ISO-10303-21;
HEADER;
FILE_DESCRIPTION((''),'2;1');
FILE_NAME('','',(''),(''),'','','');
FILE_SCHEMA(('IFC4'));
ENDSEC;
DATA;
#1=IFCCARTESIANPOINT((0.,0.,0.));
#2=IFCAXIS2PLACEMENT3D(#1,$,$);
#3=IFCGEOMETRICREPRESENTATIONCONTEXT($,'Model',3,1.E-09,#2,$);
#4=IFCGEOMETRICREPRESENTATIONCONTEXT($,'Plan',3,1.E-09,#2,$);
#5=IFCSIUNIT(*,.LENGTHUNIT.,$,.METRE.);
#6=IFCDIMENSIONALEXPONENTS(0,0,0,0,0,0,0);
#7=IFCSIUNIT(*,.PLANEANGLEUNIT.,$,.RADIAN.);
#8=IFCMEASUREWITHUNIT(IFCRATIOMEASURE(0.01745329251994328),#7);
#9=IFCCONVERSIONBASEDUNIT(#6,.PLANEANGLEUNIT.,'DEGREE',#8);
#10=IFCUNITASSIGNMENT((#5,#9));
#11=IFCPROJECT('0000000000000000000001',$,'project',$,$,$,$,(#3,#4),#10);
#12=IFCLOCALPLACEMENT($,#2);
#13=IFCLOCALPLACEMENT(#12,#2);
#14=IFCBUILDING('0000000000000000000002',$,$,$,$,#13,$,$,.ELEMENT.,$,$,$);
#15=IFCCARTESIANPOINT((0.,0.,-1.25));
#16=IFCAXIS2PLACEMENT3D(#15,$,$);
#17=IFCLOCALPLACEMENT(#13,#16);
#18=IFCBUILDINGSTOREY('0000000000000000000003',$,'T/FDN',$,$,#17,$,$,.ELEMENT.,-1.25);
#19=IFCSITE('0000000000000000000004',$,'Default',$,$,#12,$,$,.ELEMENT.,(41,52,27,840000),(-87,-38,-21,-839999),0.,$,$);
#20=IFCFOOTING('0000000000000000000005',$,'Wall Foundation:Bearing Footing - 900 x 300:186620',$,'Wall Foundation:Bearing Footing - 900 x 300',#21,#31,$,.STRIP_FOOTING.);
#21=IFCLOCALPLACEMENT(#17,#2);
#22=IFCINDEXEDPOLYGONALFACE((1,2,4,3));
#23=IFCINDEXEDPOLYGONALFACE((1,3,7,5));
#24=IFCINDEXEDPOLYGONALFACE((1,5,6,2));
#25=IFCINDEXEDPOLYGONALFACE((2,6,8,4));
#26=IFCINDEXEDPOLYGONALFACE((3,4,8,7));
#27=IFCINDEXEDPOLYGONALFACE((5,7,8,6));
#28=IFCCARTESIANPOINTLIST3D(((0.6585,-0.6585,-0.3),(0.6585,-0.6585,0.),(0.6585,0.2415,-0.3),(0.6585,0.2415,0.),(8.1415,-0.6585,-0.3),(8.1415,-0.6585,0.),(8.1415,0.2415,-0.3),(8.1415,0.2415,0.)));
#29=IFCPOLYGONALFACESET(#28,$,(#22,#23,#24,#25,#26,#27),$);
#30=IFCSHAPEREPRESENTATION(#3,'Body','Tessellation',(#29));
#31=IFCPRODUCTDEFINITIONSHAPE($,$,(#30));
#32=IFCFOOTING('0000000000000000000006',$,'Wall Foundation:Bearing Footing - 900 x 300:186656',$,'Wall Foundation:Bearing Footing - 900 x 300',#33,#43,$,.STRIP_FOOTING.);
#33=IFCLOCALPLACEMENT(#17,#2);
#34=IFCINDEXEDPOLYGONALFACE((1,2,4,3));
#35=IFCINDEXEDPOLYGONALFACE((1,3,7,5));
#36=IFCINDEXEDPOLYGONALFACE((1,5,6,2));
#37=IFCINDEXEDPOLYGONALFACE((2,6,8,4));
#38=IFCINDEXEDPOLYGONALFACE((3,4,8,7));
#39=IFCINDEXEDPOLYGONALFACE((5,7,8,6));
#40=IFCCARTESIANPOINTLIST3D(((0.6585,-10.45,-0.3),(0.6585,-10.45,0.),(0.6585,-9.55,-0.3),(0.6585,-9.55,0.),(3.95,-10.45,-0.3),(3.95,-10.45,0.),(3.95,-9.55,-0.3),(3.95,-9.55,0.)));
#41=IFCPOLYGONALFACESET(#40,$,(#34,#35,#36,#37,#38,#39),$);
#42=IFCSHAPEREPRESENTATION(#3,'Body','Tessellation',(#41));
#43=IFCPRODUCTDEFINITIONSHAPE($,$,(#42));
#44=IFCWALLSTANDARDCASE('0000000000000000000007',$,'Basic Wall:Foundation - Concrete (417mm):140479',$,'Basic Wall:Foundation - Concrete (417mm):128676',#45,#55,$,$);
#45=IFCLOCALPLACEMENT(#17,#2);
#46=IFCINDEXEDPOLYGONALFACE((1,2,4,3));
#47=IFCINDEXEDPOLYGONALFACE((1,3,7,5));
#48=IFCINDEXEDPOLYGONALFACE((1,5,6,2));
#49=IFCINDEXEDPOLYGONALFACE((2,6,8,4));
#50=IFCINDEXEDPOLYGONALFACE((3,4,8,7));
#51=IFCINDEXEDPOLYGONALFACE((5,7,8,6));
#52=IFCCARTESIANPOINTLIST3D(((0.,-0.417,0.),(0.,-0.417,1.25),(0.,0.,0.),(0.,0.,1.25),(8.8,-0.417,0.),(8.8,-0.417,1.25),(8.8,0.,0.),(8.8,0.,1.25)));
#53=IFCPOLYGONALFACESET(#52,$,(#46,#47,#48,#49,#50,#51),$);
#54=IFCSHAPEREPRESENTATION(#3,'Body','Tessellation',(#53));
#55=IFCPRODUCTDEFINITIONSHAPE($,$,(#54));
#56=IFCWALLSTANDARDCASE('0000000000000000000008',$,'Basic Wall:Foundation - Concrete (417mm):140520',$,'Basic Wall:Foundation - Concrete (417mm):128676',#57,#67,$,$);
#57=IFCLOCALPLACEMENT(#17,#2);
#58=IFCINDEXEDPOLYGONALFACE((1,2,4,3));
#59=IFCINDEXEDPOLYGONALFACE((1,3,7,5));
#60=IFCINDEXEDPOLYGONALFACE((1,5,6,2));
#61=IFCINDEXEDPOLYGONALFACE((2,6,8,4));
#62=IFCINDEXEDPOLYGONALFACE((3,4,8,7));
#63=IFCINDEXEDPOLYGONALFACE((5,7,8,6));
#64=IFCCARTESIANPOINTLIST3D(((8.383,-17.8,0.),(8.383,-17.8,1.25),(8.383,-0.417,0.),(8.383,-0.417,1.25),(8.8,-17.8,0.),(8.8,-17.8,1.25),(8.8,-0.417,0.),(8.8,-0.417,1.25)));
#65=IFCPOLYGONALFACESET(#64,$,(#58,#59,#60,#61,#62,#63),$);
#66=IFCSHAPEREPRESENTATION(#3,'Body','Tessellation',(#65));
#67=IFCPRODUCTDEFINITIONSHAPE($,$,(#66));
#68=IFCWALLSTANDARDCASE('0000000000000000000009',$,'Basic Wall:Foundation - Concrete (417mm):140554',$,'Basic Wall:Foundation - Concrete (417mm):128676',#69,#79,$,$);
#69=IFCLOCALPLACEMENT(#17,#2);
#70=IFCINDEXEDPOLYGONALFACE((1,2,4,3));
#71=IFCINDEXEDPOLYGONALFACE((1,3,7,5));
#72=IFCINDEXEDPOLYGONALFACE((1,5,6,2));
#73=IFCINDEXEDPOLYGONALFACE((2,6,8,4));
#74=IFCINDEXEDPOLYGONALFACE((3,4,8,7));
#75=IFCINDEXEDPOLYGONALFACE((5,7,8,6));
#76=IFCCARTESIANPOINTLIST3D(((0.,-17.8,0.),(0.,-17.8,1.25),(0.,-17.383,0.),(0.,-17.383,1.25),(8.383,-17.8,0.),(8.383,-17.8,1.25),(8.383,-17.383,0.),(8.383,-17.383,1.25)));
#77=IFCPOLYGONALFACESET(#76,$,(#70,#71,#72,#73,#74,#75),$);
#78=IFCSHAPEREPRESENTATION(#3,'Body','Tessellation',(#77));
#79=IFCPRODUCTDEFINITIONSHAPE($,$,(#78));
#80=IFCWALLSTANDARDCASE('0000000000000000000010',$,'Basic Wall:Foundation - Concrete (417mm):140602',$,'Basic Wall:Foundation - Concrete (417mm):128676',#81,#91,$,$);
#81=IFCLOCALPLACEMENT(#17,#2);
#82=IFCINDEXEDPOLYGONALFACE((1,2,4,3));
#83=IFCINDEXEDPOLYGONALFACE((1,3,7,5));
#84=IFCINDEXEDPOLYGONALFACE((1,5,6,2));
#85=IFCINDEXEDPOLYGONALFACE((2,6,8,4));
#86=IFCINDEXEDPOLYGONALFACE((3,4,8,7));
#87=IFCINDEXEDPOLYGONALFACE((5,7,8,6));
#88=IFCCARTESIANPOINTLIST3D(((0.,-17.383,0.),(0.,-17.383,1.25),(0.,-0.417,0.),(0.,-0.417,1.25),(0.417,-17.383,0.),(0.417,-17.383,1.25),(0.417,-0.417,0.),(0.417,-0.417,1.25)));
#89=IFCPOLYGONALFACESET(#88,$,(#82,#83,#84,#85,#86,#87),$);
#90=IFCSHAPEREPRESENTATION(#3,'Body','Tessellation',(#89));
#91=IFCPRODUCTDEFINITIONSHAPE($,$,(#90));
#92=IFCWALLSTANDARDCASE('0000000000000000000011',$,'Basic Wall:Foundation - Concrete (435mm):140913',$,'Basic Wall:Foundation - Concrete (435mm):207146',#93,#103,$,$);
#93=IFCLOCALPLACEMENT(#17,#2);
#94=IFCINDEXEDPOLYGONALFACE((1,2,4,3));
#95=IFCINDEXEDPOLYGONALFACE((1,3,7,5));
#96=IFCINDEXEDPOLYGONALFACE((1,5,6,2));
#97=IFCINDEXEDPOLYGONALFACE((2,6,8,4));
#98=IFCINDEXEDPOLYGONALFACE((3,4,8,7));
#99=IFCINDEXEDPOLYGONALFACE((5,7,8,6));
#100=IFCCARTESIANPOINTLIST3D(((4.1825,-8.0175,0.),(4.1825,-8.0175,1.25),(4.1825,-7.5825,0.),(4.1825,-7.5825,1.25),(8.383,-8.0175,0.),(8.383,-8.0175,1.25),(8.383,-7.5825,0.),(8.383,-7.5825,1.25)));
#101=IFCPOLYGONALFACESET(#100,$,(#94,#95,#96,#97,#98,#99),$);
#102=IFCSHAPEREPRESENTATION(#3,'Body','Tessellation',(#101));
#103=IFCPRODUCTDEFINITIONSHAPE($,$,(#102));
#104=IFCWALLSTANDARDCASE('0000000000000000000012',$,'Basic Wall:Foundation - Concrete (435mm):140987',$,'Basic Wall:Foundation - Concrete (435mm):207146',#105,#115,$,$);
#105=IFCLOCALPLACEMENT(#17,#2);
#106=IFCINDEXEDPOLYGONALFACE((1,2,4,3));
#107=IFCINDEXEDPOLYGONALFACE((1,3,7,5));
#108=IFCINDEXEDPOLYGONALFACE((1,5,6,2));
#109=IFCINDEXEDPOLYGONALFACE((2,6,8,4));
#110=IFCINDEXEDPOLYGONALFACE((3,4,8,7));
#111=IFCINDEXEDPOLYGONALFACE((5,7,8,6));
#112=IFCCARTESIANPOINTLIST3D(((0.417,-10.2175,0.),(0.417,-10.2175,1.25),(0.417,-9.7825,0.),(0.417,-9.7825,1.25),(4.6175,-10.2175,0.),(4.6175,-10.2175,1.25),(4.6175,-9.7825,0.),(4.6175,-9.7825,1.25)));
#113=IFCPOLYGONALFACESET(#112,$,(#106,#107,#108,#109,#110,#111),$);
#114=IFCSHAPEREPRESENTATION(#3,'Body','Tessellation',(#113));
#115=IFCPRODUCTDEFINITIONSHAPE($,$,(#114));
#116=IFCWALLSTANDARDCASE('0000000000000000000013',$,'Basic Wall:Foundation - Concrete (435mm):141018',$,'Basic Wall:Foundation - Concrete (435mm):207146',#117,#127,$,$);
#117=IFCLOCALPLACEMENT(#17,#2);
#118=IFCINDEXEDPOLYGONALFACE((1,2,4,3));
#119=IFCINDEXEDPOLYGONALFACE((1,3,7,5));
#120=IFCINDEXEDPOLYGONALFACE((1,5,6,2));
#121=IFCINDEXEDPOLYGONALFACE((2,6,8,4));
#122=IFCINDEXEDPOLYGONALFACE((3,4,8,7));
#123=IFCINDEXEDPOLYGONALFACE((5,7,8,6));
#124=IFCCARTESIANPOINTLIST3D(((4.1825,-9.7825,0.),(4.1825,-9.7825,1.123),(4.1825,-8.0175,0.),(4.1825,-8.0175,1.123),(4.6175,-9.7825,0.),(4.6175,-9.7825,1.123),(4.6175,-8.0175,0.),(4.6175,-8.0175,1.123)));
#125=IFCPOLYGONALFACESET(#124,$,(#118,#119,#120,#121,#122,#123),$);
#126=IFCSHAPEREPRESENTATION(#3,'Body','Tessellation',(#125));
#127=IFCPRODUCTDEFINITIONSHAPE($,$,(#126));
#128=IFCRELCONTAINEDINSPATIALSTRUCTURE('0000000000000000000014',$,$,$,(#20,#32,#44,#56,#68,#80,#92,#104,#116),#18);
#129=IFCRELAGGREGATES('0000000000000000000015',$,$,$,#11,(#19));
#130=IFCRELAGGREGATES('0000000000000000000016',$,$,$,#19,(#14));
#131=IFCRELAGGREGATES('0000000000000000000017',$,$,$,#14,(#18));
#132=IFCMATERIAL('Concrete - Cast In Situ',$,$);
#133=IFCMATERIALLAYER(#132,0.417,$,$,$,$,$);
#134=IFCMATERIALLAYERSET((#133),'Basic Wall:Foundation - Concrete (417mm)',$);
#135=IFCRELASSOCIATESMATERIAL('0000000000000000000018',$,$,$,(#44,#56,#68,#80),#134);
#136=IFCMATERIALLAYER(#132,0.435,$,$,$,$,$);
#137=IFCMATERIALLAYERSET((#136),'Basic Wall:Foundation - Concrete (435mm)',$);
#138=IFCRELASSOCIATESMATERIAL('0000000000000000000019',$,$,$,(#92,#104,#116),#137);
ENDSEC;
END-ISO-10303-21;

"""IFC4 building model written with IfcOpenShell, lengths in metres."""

from ifc_helpers import new_model, entity, si_unit, converted_unit, frame, frame_2d, origin, origin_2d_with_axis, place, context, project, spatial, rectangle, extrude, material, layer, layer_set, layer_usage, element, save


model = new_model("IFC4")

# Units and contexts
model_context = context("Model", 3, precision=1e-09, world=origin())
plan_context = context("Plan", 3, precision=1e-09, world=origin())
ifc_project = project(units=[si_unit("LENGTHUNIT", "METRE"), converted_unit("PLANEANGLEUNIT", "DEGREE", entity("IfcRatioMeasure", 0.01745329251994328), si_unit("PLANEANGLEUNIT", "RADIAN"), dimensions=[0, 0, 0, 0, 0, 0, 0])], contexts=[model_context, plan_context])

# Site, building, storey
site_placement = place(None, origin())
site = spatial("IfcSite", under=ifc_project, at=site_placement, Name="Default", CompositionType="ELEMENT", RefLatitude=(41, 52, 27, 840000), RefLongitude=(-87, -38, -21, -839999), RefElevation=0.0)
building_placement = place(site_placement, origin())
building = spatial("IfcBuilding", under=site, at=building_placement, CompositionType="ELEMENT")
storey_placement = place(building_placement, frame((0.0, 0.0, -1.25)))
storey = spatial("IfcBuildingStorey", under=building, at=storey_placement, Name="T/FDN", CompositionType="ELEMENT", Elevation=-1.25)

# Footings
footing_1_placement = place(storey_placement, origin())
element("IfcFooting", 1, at=footing_1_placement, inside=storey, Name="Wall Foundation:Bearing Footing - 900 x 300:186620", ObjectType="Wall Foundation:Bearing Footing - 900 x 300", PredefinedType="STRIP_FOOTING", context=model_context, shape_type="SweptSolid", body=[
    extrude(rectangle(XDim=7.483, YDim=0.9, at=origin_2d_with_axis()), frame((4.4, -0.2085, -0.3), z_axis=(0.0, 0.0, 1.0), x_axis=(-1.0, 0.0, 0.0)), (0.0, 0.0, 1.0), 0.3),
])
footing_2_placement = place(storey_placement, origin())
element("IfcFooting", 2, at=footing_2_placement, inside=storey, Name="Wall Foundation:Bearing Footing - 900 x 300:186656", ObjectType="Wall Foundation:Bearing Footing - 900 x 300", PredefinedType="STRIP_FOOTING", context=model_context, shape_type="SweptSolid", body=[
    extrude(rectangle(XDim=3.2915, YDim=0.9, at=origin_2d_with_axis()), frame((2.3042, -10.0, -0.3)), (0.0, 0.0, 1.0), 0.3),
])

# Walls
ifc_material = material(Name="Concrete - Cast In Situ")
ifc_layer_1 = layer(ifc_material, 0.417)
ifc_layer_set_1 = layer_set([ifc_layer_1], Name="Basic Wall:Foundation - Concrete (417mm)")
ifc_layer_usage_1 = layer_usage(ifc_layer_set_1, "AXIS2", "NEGATIVE", 0.2085)
wall_1_placement = place(storey_placement, frame((0.0, -0.2085, 0.0)))
element("IfcWallStandardCase", 3, at=wall_1_placement, inside=storey, material=ifc_layer_usage_1, Name="Basic Wall:Foundation - Concrete (417mm):140479", ObjectType="Basic Wall:Foundation - Concrete (417mm):128676", context=model_context, shape_type="SweptSolid", body=[
    extrude(rectangle(XDim=8.8, YDim=0.417, at=frame_2d((4.4, 0.0), x_axis=(-1.0, 0.0))), origin(), (0.0, 0.0, 1.0), 1.25),
])
ifc_layer_usage_2 = layer_usage(ifc_layer_set_1, "AXIS2", "NEGATIVE", 0.2085)
wall_2_placement = place(storey_placement, frame((8.5915, -0.417, 0.0), z_axis=(0.0, 0.0, 1.0), x_axis=(0.0, -1.0, 0.0)))
element("IfcWallStandardCase", 4, at=wall_2_placement, inside=storey, material=ifc_layer_usage_2, Name="Basic Wall:Foundation - Concrete (417mm):140520", ObjectType="Basic Wall:Foundation - Concrete (417mm):128676", context=model_context, shape_type="SweptSolid", body=[
    extrude(rectangle(XDim=17.383, YDim=0.417, at=frame_2d((8.6915, 0.0), x_axis=(-1.0, 0.0))), origin(), (0.0, 0.0, 1.0), 1.25),
])
ifc_layer_usage_3 = layer_usage(ifc_layer_set_1, "AXIS2", "NEGATIVE", 0.2085)
wall_3_placement = place(storey_placement, frame((8.383, -17.5915, 0.0), z_axis=(0.0, 0.0, 1.0), x_axis=(-1.0, 0.0, 0.0)))
element("IfcWallStandardCase", 5, at=wall_3_placement, inside=storey, material=ifc_layer_usage_3, Name="Basic Wall:Foundation - Concrete (417mm):140554", ObjectType="Basic Wall:Foundation - Concrete (417mm):128676", context=model_context, shape_type="SweptSolid", body=[
    extrude(rectangle(XDim=8.383, YDim=0.417, at=frame_2d((4.1915, 0.0), x_axis=(-1.0, 0.0))), origin(), (0.0, 0.0, 1.0), 1.25),
])
ifc_layer_usage_4 = layer_usage(ifc_layer_set_1, "AXIS2", "NEGATIVE", 0.2085)
wall_4_placement = place(storey_placement, frame((0.2085, -17.383, 0.0), z_axis=(0.0, 0.0, 1.0), x_axis=(0.0, 1.0, 0.0)))
element("IfcWallStandardCase", 6, at=wall_4_placement, inside=storey, material=ifc_layer_usage_4, Name="Basic Wall:Foundation - Concrete (417mm):140602", ObjectType="Basic Wall:Foundation - Concrete (417mm):128676", context=model_context, shape_type="SweptSolid", body=[
    extrude(rectangle(XDim=16.966, YDim=0.417, at=frame_2d((8.483, 0.0), x_axis=(-1.0, 0.0))), origin(), (0.0, 0.0, 1.0), 1.25),
])
ifc_layer_2 = layer(ifc_material, 0.435)
ifc_layer_set_2 = layer_set([ifc_layer_2], Name="Basic Wall:Foundation - Concrete (435mm)")
ifc_layer_usage_5 = layer_usage(ifc_layer_set_2, "AXIS2", "NEGATIVE", 0.2175)
wall_5_placement = place(storey_placement, frame((8.383, -7.8, 0.0), z_axis=(0.0, 0.0, 1.0), x_axis=(-1.0, 0.0, 0.0)))
element("IfcWallStandardCase", 7, at=wall_5_placement, inside=storey, material=ifc_layer_usage_5, Name="Basic Wall:Foundation - Concrete (435mm):140913", ObjectType="Basic Wall:Foundation - Concrete (435mm):207146", context=model_context, shape_type="SweptSolid", body=[
    extrude(rectangle(XDim=4.2005, YDim=0.435, at=frame_2d((2.1002, 0.0), x_axis=(-1.0, 0.0))), origin(), (0.0, 0.0, 1.0), 1.25),
])
ifc_layer_usage_6 = layer_usage(ifc_layer_set_2, "AXIS2", "NEGATIVE", 0.2175)
wall_6_placement = place(storey_placement, frame((0.417, -10.0, 0.0)))
element("IfcWallStandardCase", 8, at=wall_6_placement, inside=storey, material=ifc_layer_usage_6, Name="Basic Wall:Foundation - Concrete (435mm):140987", ObjectType="Basic Wall:Foundation - Concrete (435mm):207146", context=model_context, shape_type="SweptSolid", body=[
    extrude(rectangle(XDim=4.2005, YDim=0.435, at=frame_2d((2.1002, 0.0), x_axis=(-1.0, 0.0))), origin(), (0.0, 0.0, 1.0), 1.25),
])
ifc_layer_usage_7 = layer_usage(ifc_layer_set_2, "AXIS2", "NEGATIVE", 0.2175)
wall_7_placement = place(storey_placement, frame((4.4, -9.7825, 0.0), z_axis=(0.0, 0.0, 1.0), x_axis=(0.0, 1.0, 0.0)))
element("IfcWallStandardCase", 9, at=wall_7_placement, inside=storey, material=ifc_layer_usage_7, Name="Basic Wall:Foundation - Concrete (435mm):141018", ObjectType="Basic Wall:Foundation - Concrete (435mm):207146", context=model_context, shape_type="SweptSolid", body=[
    extrude(rectangle(XDim=1.765, YDim=0.435, at=frame_2d((0.8825, 0.0), x_axis=(-1.0, 0.0))), origin(), (0.0, 0.0, 1.0), 1.123),
])

save(model, "model.ifc")
